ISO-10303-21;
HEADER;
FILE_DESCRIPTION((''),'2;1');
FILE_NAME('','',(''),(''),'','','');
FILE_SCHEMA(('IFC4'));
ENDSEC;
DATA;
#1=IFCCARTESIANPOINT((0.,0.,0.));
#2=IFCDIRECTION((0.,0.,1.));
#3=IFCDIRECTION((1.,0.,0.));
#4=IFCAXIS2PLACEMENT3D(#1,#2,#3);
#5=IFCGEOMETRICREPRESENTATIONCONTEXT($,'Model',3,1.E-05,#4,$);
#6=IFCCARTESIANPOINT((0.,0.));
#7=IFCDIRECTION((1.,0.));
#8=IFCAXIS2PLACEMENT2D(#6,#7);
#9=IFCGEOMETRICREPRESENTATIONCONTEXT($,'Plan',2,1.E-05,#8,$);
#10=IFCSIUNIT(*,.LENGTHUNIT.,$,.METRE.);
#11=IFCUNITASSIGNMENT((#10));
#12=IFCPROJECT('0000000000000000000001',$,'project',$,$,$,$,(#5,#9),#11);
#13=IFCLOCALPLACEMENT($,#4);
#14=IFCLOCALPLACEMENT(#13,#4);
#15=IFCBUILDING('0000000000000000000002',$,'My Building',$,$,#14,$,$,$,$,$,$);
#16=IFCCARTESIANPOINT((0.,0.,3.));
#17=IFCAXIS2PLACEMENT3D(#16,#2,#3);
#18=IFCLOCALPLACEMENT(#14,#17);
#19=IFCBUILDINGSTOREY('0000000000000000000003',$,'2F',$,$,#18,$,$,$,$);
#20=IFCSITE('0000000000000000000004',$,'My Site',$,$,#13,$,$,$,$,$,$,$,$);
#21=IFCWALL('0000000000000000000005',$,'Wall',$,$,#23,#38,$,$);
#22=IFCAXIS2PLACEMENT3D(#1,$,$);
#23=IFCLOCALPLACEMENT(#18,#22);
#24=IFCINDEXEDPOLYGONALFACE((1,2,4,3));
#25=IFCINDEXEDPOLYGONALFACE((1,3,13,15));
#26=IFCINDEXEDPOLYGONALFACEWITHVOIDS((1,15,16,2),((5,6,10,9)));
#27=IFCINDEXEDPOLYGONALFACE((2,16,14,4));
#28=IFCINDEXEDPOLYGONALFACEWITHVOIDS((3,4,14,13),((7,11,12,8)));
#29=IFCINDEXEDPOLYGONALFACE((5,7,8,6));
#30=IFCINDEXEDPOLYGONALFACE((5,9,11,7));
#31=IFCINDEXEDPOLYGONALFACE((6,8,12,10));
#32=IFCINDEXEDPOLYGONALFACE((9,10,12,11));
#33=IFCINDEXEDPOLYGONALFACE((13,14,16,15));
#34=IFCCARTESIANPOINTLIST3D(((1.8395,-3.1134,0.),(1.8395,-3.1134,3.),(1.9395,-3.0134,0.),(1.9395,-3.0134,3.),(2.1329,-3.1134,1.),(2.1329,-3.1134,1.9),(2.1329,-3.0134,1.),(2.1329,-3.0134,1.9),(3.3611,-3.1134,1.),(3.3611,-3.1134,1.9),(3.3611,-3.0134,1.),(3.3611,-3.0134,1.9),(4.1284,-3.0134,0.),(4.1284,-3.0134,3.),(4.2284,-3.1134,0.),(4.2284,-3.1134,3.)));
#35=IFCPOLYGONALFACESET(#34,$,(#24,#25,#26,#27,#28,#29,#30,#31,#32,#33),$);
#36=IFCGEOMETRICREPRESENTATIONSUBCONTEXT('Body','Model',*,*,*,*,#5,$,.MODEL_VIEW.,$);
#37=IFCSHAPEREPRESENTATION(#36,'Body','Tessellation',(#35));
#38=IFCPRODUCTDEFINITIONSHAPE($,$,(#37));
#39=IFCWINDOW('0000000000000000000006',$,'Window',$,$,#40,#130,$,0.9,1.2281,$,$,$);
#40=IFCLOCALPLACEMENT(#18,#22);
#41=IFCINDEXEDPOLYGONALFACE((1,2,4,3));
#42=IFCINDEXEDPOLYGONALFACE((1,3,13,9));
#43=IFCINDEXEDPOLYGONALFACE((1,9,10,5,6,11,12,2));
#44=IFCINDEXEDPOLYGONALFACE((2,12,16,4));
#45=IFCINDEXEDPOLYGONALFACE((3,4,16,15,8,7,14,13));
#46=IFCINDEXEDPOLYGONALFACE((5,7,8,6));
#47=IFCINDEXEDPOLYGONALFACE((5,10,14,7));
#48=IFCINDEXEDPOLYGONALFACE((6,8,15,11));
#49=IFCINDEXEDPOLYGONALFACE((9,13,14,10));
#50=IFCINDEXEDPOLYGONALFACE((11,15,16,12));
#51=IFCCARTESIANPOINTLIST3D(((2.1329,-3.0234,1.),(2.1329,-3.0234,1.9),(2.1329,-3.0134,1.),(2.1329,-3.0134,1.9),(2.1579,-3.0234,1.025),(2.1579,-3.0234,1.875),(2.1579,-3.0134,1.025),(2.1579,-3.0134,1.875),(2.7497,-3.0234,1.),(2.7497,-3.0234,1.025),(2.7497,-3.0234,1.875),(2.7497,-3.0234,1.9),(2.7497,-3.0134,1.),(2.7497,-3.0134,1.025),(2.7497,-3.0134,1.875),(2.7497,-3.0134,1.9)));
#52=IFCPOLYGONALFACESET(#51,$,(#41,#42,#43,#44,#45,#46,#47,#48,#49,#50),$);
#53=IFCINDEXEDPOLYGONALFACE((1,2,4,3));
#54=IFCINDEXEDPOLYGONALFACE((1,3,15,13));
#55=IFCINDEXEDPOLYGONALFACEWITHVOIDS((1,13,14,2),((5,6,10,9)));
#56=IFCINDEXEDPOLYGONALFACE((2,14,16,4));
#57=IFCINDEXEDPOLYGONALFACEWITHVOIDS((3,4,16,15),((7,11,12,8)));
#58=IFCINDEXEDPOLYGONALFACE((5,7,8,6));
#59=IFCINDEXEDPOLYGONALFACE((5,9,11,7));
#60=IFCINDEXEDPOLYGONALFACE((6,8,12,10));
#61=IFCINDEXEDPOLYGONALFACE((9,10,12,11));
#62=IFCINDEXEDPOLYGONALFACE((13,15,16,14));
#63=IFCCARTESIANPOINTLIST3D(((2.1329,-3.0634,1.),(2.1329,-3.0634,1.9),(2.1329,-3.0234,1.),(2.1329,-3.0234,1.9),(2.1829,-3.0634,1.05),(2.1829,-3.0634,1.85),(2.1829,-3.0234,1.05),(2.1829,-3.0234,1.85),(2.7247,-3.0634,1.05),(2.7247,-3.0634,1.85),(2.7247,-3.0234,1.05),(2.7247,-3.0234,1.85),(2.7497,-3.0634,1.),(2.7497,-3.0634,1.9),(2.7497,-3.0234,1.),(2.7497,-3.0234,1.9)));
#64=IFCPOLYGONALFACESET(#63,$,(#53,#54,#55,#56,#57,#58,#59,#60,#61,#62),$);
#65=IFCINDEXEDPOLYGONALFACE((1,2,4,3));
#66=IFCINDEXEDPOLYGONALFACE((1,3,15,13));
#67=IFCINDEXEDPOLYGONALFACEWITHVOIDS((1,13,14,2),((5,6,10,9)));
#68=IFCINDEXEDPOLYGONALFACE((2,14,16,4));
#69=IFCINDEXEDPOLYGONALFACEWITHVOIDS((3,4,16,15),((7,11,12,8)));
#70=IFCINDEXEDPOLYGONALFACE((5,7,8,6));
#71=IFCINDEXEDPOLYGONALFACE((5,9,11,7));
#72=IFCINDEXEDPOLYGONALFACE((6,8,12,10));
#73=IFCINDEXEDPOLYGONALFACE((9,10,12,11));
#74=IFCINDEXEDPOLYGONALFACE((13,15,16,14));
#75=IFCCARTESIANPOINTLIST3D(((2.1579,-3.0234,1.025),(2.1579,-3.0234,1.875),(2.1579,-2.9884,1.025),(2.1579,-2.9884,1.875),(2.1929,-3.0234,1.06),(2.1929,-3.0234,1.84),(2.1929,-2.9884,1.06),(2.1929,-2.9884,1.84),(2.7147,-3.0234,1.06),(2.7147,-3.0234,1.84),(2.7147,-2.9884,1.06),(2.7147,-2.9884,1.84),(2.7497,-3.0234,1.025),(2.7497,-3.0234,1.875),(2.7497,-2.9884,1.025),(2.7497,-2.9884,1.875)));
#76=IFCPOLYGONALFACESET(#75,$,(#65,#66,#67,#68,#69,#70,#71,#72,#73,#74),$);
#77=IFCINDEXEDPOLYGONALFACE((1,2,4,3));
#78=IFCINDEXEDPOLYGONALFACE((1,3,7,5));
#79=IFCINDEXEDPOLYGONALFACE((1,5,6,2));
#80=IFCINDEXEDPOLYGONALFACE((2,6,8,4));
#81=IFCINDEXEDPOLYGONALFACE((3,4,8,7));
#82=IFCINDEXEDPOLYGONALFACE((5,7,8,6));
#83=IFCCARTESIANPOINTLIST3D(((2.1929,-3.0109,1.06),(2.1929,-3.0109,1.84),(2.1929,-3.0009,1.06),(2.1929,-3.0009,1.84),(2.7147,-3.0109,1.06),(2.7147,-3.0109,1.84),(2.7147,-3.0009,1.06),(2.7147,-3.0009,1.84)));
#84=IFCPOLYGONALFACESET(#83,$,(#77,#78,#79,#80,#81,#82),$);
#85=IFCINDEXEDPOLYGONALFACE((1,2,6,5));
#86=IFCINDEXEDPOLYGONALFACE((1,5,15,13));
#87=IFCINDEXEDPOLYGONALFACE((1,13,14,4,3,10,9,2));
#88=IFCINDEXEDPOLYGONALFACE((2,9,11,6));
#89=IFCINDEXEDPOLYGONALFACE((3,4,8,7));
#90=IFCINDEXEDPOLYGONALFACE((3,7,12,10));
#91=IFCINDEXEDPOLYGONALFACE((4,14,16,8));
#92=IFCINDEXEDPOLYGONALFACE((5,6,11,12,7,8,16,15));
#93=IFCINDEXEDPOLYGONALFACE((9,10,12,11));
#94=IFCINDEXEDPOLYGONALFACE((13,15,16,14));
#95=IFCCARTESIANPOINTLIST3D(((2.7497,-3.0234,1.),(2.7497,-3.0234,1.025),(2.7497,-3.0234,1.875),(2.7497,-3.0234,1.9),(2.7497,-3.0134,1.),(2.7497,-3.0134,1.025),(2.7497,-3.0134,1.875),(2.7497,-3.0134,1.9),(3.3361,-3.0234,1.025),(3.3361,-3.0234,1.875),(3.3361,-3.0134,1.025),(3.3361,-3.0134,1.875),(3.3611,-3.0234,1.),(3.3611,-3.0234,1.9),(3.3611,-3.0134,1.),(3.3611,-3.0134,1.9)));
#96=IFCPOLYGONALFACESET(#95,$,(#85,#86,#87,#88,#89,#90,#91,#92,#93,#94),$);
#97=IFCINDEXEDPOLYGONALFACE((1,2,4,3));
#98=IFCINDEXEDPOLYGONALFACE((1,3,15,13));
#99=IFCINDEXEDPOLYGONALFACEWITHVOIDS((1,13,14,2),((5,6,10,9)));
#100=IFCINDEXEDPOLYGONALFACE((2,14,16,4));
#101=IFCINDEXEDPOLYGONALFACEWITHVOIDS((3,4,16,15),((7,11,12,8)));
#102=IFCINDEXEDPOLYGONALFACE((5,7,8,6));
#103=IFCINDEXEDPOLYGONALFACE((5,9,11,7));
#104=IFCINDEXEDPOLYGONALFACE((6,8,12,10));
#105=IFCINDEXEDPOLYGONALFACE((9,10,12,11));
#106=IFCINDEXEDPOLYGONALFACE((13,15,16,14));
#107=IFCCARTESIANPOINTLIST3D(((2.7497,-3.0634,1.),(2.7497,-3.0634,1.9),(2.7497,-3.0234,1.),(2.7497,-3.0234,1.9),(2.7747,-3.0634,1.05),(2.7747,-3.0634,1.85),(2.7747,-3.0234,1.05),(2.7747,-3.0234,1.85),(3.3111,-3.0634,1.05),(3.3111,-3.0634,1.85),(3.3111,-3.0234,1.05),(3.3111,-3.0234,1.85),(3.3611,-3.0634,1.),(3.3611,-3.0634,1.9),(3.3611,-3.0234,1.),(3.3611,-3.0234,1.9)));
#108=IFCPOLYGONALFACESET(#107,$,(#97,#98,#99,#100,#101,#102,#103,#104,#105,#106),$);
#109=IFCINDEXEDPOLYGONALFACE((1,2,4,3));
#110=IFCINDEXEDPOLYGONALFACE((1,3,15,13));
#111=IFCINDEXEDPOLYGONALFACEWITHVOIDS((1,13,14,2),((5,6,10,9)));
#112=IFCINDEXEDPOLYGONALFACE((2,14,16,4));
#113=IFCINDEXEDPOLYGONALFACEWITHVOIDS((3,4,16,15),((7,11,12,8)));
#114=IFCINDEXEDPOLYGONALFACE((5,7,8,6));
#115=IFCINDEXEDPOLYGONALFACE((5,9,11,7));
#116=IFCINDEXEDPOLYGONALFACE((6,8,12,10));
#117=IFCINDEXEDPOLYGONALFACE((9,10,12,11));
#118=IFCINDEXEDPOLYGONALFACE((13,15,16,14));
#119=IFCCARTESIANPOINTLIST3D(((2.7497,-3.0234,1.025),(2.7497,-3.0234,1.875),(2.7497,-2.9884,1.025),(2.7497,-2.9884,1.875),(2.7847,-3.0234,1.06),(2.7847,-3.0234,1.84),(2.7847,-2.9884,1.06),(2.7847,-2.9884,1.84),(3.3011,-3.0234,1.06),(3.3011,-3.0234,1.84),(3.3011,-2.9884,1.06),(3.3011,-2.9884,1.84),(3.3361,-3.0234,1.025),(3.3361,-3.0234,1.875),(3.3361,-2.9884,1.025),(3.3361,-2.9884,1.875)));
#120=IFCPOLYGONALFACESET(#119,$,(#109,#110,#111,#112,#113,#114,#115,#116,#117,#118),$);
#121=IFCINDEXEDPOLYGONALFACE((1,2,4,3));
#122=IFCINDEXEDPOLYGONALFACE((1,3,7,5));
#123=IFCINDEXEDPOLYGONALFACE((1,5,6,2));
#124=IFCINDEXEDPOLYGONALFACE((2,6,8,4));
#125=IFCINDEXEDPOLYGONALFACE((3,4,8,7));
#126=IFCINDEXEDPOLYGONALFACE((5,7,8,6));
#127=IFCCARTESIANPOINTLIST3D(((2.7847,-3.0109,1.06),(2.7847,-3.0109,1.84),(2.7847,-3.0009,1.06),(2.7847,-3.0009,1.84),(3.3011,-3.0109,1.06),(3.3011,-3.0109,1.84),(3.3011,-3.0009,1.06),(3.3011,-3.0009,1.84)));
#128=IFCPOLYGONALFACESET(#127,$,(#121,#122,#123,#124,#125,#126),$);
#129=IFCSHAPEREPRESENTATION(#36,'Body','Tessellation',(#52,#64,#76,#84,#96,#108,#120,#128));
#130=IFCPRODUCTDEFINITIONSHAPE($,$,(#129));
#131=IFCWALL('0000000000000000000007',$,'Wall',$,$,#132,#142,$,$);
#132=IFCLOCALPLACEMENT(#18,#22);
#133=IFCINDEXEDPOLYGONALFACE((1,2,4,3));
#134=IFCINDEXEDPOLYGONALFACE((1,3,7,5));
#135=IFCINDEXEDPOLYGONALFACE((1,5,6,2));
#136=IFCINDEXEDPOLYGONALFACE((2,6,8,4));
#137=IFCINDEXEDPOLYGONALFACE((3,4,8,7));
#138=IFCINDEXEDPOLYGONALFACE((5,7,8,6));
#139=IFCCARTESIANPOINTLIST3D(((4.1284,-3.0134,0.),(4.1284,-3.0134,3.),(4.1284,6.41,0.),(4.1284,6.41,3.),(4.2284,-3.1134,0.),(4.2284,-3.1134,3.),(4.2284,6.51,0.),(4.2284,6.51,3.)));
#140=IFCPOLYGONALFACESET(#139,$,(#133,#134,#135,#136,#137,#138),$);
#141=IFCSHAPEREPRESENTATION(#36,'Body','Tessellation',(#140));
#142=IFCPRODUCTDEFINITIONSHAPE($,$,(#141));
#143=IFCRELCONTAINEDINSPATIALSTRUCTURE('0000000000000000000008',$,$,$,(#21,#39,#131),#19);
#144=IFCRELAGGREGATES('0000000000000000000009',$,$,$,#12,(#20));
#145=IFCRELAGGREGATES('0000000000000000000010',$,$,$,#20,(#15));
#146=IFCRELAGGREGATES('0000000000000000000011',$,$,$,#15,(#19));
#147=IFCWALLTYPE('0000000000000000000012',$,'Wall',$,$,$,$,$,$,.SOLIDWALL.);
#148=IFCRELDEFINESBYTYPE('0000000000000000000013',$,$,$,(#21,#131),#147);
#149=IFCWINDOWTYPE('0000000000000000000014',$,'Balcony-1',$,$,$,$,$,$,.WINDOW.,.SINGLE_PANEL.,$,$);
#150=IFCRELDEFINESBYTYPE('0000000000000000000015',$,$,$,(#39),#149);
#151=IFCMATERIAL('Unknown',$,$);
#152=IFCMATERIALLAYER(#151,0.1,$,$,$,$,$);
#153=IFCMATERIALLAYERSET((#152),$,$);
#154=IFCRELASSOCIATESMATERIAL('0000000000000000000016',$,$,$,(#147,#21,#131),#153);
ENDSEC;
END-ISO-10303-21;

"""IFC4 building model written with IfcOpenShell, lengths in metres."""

from ifc_helpers import new_model, entity, si_unit, frame, origin_with_axes, origin_2d_with_axis, place, context, subcontext, project, spatial, line, indexed_curve, outline, extrude, shape, source, transform, mapped, material, layer, layer_set, layer_usage, type_object, type_shapes, element, fill, save


model = new_model("IFC4")

# Units and contexts
model_context_1 = context("Model", 3, precision=1e-05, world=origin_with_axes())
plan_context = context("Plan", 2, precision=1e-05, world=origin_2d_with_axis())
body_context_1 = subcontext(model_context_1, "Body", "Model", "MODEL_VIEW")
body_context_2 = subcontext(plan_context, "Body", "Plan", "PLAN_VIEW")
ifc_project = project(units=[si_unit("LENGTHUNIT", "METRE")], contexts=[model_context_1, plan_context])

# Site, building, storey
site_placement = place(None, origin_with_axes())
site = spatial("IfcSite", under=ifc_project, at=site_placement, Name="My Site")
building_placement = place(site_placement, origin_with_axes())
building = spatial("IfcBuilding", under=site, at=building_placement, Name="My Building")
storey_placement = place(building_placement, frame((0.0, 0.0, 3.0), z_axis=(0.0, 0.0, 1.0), x_axis=(1.0, 0.0, 0.0)))
storey = spatial("IfcBuildingStorey", under=building, at=storey_placement, Name="2F")

# Shared definitions
ifc_material_1 = material(Name="Unknown")
ifc_layer = layer(ifc_material_1, 0.1)
ifc_layer_set = layer_set([ifc_layer])
wall_type = type_object("IfcWallType", Name="Wall", PredefinedType="SOLIDWALL", material=ifc_layer_set)

# Wall, opening, window
ifc_layer_usage_1 = layer_usage(ifc_layer_set, "AXIS2", "POSITIVE", 0.0)
wall_1_placement = place(storey_placement, frame((1.8395, -3.1134, 0.0), z_axis=(0.0, 0.0, 1.0), x_axis=(1.0, 0.0, 0.0)))
wall_1 = element("IfcWall", 1, at=wall_1_placement, inside=storey, type_object=wall_type, material=ifc_layer_usage_1, Name="Wall", context=body_context_1, shape_type="SweptSolid", body=[
    extrude(outline(indexed_curve([(0.0, 0.0), (0.1, 0.1), (2.2889, 0.1), (2.3889, 0.0)], segments=[line(1, 2, 3, 4, 1)])), origin_with_axes(), (0.0, 0.0, 1.0), 3.0),
])
shared_shape_1 = source(origin_with_axes(), body_context_1, "Body", "SweptSolid", [
    extrude(outline(indexed_curve([(0.0, 0.0), (1.2281, 0.0), (1.2281, 0.9), (0.0, 0.9)], segments=[line(1, 2, 3, 4, 1)])), frame((0.0, -0.6, 0.0), z_axis=(0.0, -1.0, 0.0), x_axis=(1.0, 0.0, 0.0)), (0.0, 0.0, -1.0), 1.2),
])
opening_1_placement = place(wall_1_placement, frame((0.2934, 0.0, 1.0), z_axis=(0.0, 0.0, 1.0), x_axis=(1.0, 0.0, 0.0)))
opening_1 = element("IfcOpeningElement", 2, at=opening_1_placement, cuts=wall_1, PredefinedType="OPENING", context=body_context_1, shape_type="MappedRepresentation", body=[
    mapped(shared_shape_1, transform((0.0, 0.0, 0.0), x_axis=(1.0, 0.0, 0.0), y_axis=(0.0, 1.0, 0.0), z_axis=(0.0, 0.0, 1.0), scale=1.0)),
])
window_type = type_object("IfcWindowType", Name="Balcony-1", PartitioningType="SINGLE_PANEL", PredefinedType="WINDOW")
shared_shape_2 = source(origin_with_axes(), body_context_1, "Body", "SweptSolid", [
    extrude(outline(indexed_curve([(0.6167, 0.0), (0.0, 0.0), (0.0, 0.9), (0.6167, 0.9), (0.6167, 0.875), (0.025, 0.875), (0.025, 0.025), (0.6167, 0.025)], segments=[line(1, 2, 3, 4, 5, 6, 7, 8, 1)])), frame((0.0, 0.09, 0.0), z_axis=(0.0, -1.0, 0.0), x_axis=(1.0, 0.0, 0.0)), (0.0, 0.0, -1.0), 0.01),
    extrude(outline(indexed_curve([(0.0, 0.0), (0.6167, 0.0), (0.6167, 0.9), (0.0, 0.9)], segments=[line(1, 2, 3, 4, 1)]), holes=[indexed_curve([(0.05, 0.05), (0.5917, 0.05), (0.5917, 0.85), (0.05, 0.85)], segments=[line(1, 2, 3, 4, 1)])]), frame((0.0, 0.05, 0.0), z_axis=(0.0, -1.0, 0.0), x_axis=(1.0, 0.0, 0.0)), (0.0, 0.0, -1.0), 0.04),
    extrude(outline(indexed_curve([(0.0, 0.0), (0.5917, 0.0), (0.5917, 0.85), (0.0, 0.85)], segments=[line(1, 2, 3, 4, 1)]), holes=[indexed_curve([(0.035, 0.035), (0.5567, 0.035), (0.5567, 0.815), (0.035, 0.815)], segments=[line(1, 2, 3, 4, 1)])]), frame((0.025, 0.09, 0.025), z_axis=(0.0, -1.0, 0.0), x_axis=(1.0, 0.0, 0.0)), (0.0, 0.0, -1.0), 0.035),
    extrude(outline(indexed_curve([(0.035, 0.035), (0.5567, 0.035), (0.5567, 0.815), (0.035, 0.815)], segments=[line(1, 2, 3, 4, 1)])), frame((0.025, 0.1025, 0.025), z_axis=(0.0, -1.0, 0.0), x_axis=(1.0, 0.0, 0.0)), (0.0, 0.0, -1.0), 0.01),
    extrude(outline(indexed_curve([(0.0, 0.9), (0.6114, 0.9), (0.6114, 0.0), (0.0, 0.0), (0.0, 0.025), (0.5864, 0.025), (0.5864, 0.875), (0.0, 0.875)], segments=[line(1, 2, 3, 4, 5, 6, 7, 8, 1)])), frame((0.6167, 0.09, 0.0), z_axis=(0.0, -1.0, 0.0), x_axis=(1.0, 0.0, 0.0)), (0.0, 0.0, -1.0), 0.01),
    extrude(outline(indexed_curve([(0.0, 0.0), (0.6114, 0.0), (0.6114, 0.9), (0.0, 0.9)], segments=[line(1, 2, 3, 4, 1)]), holes=[indexed_curve([(0.025, 0.05), (0.5614, 0.05), (0.5614, 0.85), (0.025, 0.85)], segments=[line(1, 2, 3, 4, 1)])]), frame((0.6167, 0.05, 0.0), z_axis=(0.0, -1.0, 0.0), x_axis=(1.0, 0.0, 0.0)), (0.0, 0.0, -1.0), 0.04),
    extrude(outline(indexed_curve([(0.0, 0.0), (0.5864, 0.0), (0.5864, 0.85), (0.0, 0.85)], segments=[line(1, 2, 3, 4, 1)]), holes=[indexed_curve([(0.035, 0.035), (0.5514, 0.035), (0.5514, 0.815), (0.035, 0.815)], segments=[line(1, 2, 3, 4, 1)])]), frame((0.6167, 0.09, 0.025), z_axis=(0.0, -1.0, 0.0), x_axis=(1.0, 0.0, 0.0)), (0.0, 0.0, -1.0), 0.035),
    extrude(outline(indexed_curve([(0.035, 0.035), (0.5514, 0.035), (0.5514, 0.815), (0.035, 0.815)], segments=[line(1, 2, 3, 4, 1)])), frame((0.6167, 0.1025, 0.025), z_axis=(0.0, -1.0, 0.0), x_axis=(1.0, 0.0, 0.0)), (0.0, 0.0, -1.0), 0.01),
])
shared_shape_3 = source(origin_with_axes(), body_context_2, "Body", "Curve2D", [
    entity("IfcIndexedPolyCurve", entity("IfcCartesianPointList2D", [[0.05, 0.05], [0.5917, 0.05]])),
    entity("IfcIndexedPolyCurve", entity("IfcCartesianPointList2D", [[0.0, 0.1], [0.025, 0.1], [0.025, 0.09], [0.05, 0.09], [0.05, 0.05], [0.0, 0.05]]), [entity("IfcLineIndex", [1, 2, 3, 4, 5, 6, 1])]),
    entity("IfcIndexedPolyCurve", entity("IfcCartesianPointList2D", [[0.6167, 0.1], [0.6167, 0.1], [0.6167, 0.09], [0.5917, 0.09], [0.5917, 0.05], [0.6167, 0.05]])),
    entity("IfcIndexedPolyCurve", entity("IfcCartesianPointList2D", [[0.025, 0.09], [0.06, 0.09], [0.06, 0.125], [0.025, 0.125]]), [entity("IfcLineIndex", [1, 2, 3, 4, 1])]),
    entity("IfcIndexedPolyCurve", entity("IfcCartesianPointList2D", [[0.6167, 0.09], [0.5817, 0.09], [0.5817, 0.125], [0.6167, 0.125]]), [entity("IfcLineIndex", [1, 2, 3, 4, 1])]),
    entity("IfcIndexedPolyCurve", entity("IfcCartesianPointList2D", [[0.06, 0.09], [0.5817, 0.09]])),
    entity("IfcIndexedPolyCurve", entity("IfcCartesianPointList2D", [[0.06, 0.125], [0.5817, 0.125]])),
    entity("IfcIndexedPolyCurve", entity("IfcCartesianPointList2D", [[0.06, 0.1075], [0.5817, 0.1075]])),
    entity("IfcIndexedPolyCurve", entity("IfcCartesianPointList2D", [[0.6417, 0.05], [1.1781, 0.05]])),
    entity("IfcIndexedPolyCurve", entity("IfcCartesianPointList2D", [[0.6167, 0.1], [0.6167, 0.1], [0.6167, 0.09], [0.6417, 0.09], [0.6417, 0.05], [0.6167, 0.05]])),
    entity("IfcIndexedPolyCurve", entity("IfcCartesianPointList2D", [[1.2281, 0.1], [1.2031, 0.1], [1.2031, 0.09], [1.1781, 0.09], [1.1781, 0.05], [1.2281, 0.05]]), [entity("IfcLineIndex", [1, 2, 3, 4, 5, 6, 1])]),
    entity("IfcIndexedPolyCurve", entity("IfcCartesianPointList2D", [[0.6167, 0.09], [0.6517, 0.09], [0.6517, 0.125], [0.6167, 0.125]]), [entity("IfcLineIndex", [1, 2, 3, 4, 1])]),
    entity("IfcIndexedPolyCurve", entity("IfcCartesianPointList2D", [[1.2031, 0.09], [1.1681, 0.09], [1.1681, 0.125], [1.2031, 0.125]]), [entity("IfcLineIndex", [1, 2, 3, 4, 1])]),
    entity("IfcIndexedPolyCurve", entity("IfcCartesianPointList2D", [[0.6517, 0.09], [1.1681, 0.09]])),
    entity("IfcIndexedPolyCurve", entity("IfcCartesianPointList2D", [[0.6517, 0.125], [1.1681, 0.125]])),
    entity("IfcIndexedPolyCurve", entity("IfcCartesianPointList2D", [[0.6517, 0.1075], [1.1681, 0.1075]])),
])
type_shapes(window_type, [shared_shape_2, shared_shape_3])
window_placement = place(opening_1_placement, frame((0.0, 0.0, 0.0), z_axis=(0.0, 0.0, 1.0), x_axis=(1.0, 0.0, 0.0)))
window = element("IfcWindow", 3, at=window_placement, inside=storey, type_object=window_type, Name="Window", OverallHeight=0.9, OverallWidth=1.2281, shapes=[
    shape(body_context_1, "Body", "MappedRepresentation", [mapped(shared_shape_2, transform((0.0, 0.0, 0.0), x_axis=(1.0, 0.0, 0.0), y_axis=(0.0, 1.0, 0.0), z_axis=(0.0, 0.0, 1.0), scale=1.0))]),
    shape(body_context_2, "Body", "MappedRepresentation", [mapped(shared_shape_3, transform((0.0, 0.0, 0.0), x_axis=(1.0, 0.0, 0.0), y_axis=(0.0, 1.0, 0.0), z_axis=(0.0, 0.0, 1.0), scale=1.0))]),
])
fill(opening_1, window)

# Wall
ifc_layer_usage_2 = layer_usage(ifc_layer_set, "AXIS2", "POSITIVE", 0.0)
wall_2_placement = place(storey_placement, frame((4.2284, -3.1134, 0.0), z_axis=(0.0, 0.0, 1.0), x_axis=(0.0, 1.0, 0.0)))
element("IfcWall", 4, at=wall_2_placement, inside=storey, type_object=wall_type, material=ifc_layer_usage_2, Name="Wall", context=body_context_1, shape_type="SweptSolid", body=[
    extrude(outline(indexed_curve([(0.0, 0.0), (0.1, 0.1), (9.5233, 0.1), (9.6233, 0.0)], segments=[line(1, 2, 3, 4, 1)])), origin_with_axes(), (0.0, 0.0, 1.0), 3.0),
])

save(model, "model.ifc")
